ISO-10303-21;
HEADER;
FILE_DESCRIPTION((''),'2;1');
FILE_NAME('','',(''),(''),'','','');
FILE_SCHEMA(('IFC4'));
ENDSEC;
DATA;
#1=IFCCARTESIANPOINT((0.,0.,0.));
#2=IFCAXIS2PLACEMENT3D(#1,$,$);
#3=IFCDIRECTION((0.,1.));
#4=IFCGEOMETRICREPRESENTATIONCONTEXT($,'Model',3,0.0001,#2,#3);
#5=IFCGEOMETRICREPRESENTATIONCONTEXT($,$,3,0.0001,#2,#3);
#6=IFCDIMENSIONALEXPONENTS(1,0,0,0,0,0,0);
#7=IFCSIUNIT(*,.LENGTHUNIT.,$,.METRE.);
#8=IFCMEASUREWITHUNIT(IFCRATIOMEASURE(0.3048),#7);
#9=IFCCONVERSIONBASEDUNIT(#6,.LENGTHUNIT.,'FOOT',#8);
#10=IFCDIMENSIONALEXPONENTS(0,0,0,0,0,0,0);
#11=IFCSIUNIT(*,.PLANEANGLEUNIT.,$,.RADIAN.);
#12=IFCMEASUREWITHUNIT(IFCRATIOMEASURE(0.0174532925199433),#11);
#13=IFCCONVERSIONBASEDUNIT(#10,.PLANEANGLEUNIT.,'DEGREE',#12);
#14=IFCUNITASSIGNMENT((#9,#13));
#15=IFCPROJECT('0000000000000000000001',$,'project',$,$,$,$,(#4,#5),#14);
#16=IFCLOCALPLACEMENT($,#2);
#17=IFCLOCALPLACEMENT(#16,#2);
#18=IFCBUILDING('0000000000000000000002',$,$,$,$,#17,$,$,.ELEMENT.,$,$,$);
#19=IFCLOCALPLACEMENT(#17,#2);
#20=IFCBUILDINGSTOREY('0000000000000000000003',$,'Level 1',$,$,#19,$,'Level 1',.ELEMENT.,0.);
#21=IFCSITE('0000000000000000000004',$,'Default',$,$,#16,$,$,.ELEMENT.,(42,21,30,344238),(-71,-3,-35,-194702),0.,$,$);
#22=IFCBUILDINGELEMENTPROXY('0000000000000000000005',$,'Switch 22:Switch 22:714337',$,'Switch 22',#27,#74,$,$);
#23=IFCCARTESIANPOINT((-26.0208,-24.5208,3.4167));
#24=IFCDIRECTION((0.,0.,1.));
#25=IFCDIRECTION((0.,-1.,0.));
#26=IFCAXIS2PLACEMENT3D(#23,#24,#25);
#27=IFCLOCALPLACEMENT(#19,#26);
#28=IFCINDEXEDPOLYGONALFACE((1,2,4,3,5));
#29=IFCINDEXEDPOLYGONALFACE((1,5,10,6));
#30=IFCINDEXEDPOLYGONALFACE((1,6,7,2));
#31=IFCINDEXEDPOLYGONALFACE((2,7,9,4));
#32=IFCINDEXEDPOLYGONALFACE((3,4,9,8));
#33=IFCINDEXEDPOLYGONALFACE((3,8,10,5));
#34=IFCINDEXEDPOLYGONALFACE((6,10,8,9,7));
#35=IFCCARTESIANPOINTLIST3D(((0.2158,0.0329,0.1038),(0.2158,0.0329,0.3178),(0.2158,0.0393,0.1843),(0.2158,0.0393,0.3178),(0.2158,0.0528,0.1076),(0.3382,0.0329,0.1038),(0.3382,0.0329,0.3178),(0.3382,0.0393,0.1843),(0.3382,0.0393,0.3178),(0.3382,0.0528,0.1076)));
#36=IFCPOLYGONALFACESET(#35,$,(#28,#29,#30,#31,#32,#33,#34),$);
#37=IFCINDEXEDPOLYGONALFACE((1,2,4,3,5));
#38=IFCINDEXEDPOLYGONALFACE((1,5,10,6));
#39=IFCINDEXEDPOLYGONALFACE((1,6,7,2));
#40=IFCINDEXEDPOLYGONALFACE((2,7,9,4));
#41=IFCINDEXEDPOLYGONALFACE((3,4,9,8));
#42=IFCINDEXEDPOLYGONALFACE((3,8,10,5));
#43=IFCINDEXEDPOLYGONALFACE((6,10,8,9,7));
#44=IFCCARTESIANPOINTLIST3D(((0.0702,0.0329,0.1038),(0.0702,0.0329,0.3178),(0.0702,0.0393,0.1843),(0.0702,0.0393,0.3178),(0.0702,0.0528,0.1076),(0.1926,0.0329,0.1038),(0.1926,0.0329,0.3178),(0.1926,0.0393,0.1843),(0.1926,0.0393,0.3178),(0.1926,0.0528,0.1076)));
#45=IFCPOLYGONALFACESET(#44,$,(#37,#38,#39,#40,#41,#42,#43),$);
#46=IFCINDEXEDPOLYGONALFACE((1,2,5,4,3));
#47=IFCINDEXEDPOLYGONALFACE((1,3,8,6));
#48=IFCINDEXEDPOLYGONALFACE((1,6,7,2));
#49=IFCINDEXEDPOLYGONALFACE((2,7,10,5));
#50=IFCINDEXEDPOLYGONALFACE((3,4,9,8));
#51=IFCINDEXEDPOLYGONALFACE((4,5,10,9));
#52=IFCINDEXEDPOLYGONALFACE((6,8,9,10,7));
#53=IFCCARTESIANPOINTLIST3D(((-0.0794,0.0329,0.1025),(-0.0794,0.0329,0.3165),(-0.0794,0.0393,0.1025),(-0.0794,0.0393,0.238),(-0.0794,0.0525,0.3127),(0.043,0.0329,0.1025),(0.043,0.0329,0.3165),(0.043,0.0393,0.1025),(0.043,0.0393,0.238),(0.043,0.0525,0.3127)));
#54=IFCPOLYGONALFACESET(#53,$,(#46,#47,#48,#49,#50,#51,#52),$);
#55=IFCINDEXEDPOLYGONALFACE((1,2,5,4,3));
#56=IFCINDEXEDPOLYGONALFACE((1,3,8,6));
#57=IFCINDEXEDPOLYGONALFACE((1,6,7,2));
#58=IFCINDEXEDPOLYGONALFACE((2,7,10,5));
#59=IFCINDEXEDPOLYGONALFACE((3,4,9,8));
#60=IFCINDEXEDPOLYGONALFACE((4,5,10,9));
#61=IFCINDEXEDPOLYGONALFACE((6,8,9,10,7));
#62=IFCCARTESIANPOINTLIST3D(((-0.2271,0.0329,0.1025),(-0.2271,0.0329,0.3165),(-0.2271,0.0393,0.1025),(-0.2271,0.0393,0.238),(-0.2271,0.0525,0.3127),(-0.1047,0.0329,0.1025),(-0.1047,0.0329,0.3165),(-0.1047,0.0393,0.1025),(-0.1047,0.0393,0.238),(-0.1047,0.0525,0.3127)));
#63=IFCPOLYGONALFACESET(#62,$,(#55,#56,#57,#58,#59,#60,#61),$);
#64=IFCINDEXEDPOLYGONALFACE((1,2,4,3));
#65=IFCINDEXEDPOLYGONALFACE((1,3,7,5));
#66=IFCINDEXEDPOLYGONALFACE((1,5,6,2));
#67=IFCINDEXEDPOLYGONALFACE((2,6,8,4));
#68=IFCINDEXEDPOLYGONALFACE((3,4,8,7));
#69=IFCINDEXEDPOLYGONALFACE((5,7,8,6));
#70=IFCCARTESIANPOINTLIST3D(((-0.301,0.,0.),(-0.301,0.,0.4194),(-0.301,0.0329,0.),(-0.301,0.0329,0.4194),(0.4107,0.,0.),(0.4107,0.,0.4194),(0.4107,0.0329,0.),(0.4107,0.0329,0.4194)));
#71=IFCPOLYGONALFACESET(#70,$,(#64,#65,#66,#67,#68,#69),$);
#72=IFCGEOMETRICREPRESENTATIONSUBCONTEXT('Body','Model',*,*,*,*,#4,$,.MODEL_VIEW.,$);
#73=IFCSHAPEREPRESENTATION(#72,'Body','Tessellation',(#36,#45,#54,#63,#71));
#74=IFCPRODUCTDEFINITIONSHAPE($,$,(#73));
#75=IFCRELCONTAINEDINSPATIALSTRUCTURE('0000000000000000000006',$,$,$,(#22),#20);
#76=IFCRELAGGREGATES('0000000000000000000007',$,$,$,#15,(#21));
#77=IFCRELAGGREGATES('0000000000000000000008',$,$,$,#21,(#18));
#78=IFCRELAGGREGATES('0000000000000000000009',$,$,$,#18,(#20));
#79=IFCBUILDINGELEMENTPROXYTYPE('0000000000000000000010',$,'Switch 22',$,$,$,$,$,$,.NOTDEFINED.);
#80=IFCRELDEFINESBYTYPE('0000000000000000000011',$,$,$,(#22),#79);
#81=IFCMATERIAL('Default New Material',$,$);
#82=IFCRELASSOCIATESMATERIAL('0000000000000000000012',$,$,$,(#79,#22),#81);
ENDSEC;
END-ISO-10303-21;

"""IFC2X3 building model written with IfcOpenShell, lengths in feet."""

from ifc_helpers import new_model, entity, si_unit, converted_unit, direction, frame, origin, origin_2d_with_axis, place, context, subcontext, project, spatial, polyline, rectangle, outline, extrude, source, transform, mapped, material, type_object, type_shapes, element, save


model = new_model("IFC2X3")

# Units and contexts
model_context = context("Model", 3, precision=0.0001, world=origin(), true_north=direction((0.0, 1.0)))
context_of_model = context(None, 3, precision=0.0001, world=origin(), true_north=direction((0.0, 1.0)))
body_context = subcontext(model_context, "Body", "Model", "MODEL_VIEW")
ifc_project = project(units=[converted_unit("LENGTHUNIT", "FOOT", entity("IfcRatioMeasure", 0.3048), si_unit("LENGTHUNIT", "METRE"), dimensions=[1, 0, 0, 0, 0, 0, 0]), converted_unit("PLANEANGLEUNIT", "DEGREE", entity("IfcRatioMeasure", 0.0174532925199433), si_unit("PLANEANGLEUNIT", "RADIAN"), dimensions=[0, 0, 0, 0, 0, 0, 0])], contexts=[model_context, context_of_model])

# Site, building, storey
site_placement = place(None, origin())
site = spatial("IfcSite", under=ifc_project, at=site_placement, Name="Default", CompositionType="ELEMENT", RefLatitude=(42, 21, 30, 344238), RefLongitude=(-71, -3, -35, -194702), RefElevation=0.0)
building_placement = place(site_placement, origin())
building = spatial("IfcBuilding", under=site, at=building_placement, CompositionType="ELEMENT")
storey_placement = place(building_placement, origin())
storey = spatial("IfcBuildingStorey", under=building, at=storey_placement, Name="Level 1", LongName="Level 1", CompositionType="ELEMENT", Elevation=0.0)

# Shared definitions
ifc_material = material(Name="Default New Material")

# Building element proxy
building_element_proxy_type_1 = type_object("IfcBuildingElementProxyType", Name="Switch 22", PredefinedType="NOTDEFINED", material=ifc_material)
shared_shape_1 = source(origin(), body_context, "Body", "SweptSolid", [
    extrude(outline(polyline([(-0.026, -0.0993), (-0.0057, -0.0993), (-0.0043, -0.0216), (0.0212, 0.1095), (0.0148, 0.1107), (-0.026, -0.0993)])), frame((0.2158, 0.0394, 0.2062), z_axis=(1.0, 0.0, 0.0), x_axis=(0.0, 0.981627, 0.190809)), (0.0, 0.0, 1.0), 0.1224),
    extrude(outline(polyline([(-0.026, -0.0993), (-0.0057, -0.0993), (-0.0043, -0.0216), (0.0212, 0.1095), (0.0148, 0.1107), (-0.026, -0.0993)])), frame((0.0702, 0.0394, 0.2062), z_axis=(1.0, 0.0, 0.0), x_axis=(0.0, 0.981627, 0.190809)), (0.0, 0.0, 1.0), 0.1224),
    extrude(outline(polyline([(-0.1021, -0.0065), (0.1119, -0.0065), (0.1119, -0.0001), (-0.0236, -0.0001), (-0.0983, 0.0131), (-0.1021, -0.0065)])), frame((-0.0794, 0.0394, 0.2145), z_axis=(1.0, 0.0, 0.0), x_axis=(0.0, 0.0, -1.0)), (0.0, 0.0, 1.0), 0.1224),
    extrude(outline(polyline([(-0.1021, -0.0065), (0.1119, -0.0065), (0.1119, -0.0001), (-0.0236, -0.0001), (-0.0983, 0.0131), (-0.1021, -0.0065)])), frame((-0.2271, 0.0394, 0.2145), z_axis=(1.0, 0.0, 0.0), x_axis=(0.0, 0.0, -1.0)), (0.0, 0.0, 1.0), 0.1224),
    extrude(rectangle(XDim=0.0329, YDim=0.7116, at=origin_2d_with_axis()), frame((0.0548, 0.0164, 0.0), z_axis=(0.0, 0.0, 1.0), x_axis=(0.0, -1.0, 0.0)), (0.0, 0.0, 1.0), 0.4194),
])
type_shapes(building_element_proxy_type_1, [shared_shape_1])
proxy_1_placement = place(storey_placement, frame((-26.0208, -24.5208, 3.4167), z_axis=(0.0, 0.0, 1.0), x_axis=(0.0, -1.0, 0.0)))
element("IfcBuildingElementProxy", 1, at=proxy_1_placement, inside=storey, type_object=building_element_proxy_type_1, material=ifc_material, Name="Switch 22:Switch 22:714337", ObjectType="Switch 22", context=body_context, shape_type="MappedRepresentation", body=[
    mapped(shared_shape_1, transform((0.0, 0.0, 0.0), scale=1.0)),
])

save(model, "model.ifc")
